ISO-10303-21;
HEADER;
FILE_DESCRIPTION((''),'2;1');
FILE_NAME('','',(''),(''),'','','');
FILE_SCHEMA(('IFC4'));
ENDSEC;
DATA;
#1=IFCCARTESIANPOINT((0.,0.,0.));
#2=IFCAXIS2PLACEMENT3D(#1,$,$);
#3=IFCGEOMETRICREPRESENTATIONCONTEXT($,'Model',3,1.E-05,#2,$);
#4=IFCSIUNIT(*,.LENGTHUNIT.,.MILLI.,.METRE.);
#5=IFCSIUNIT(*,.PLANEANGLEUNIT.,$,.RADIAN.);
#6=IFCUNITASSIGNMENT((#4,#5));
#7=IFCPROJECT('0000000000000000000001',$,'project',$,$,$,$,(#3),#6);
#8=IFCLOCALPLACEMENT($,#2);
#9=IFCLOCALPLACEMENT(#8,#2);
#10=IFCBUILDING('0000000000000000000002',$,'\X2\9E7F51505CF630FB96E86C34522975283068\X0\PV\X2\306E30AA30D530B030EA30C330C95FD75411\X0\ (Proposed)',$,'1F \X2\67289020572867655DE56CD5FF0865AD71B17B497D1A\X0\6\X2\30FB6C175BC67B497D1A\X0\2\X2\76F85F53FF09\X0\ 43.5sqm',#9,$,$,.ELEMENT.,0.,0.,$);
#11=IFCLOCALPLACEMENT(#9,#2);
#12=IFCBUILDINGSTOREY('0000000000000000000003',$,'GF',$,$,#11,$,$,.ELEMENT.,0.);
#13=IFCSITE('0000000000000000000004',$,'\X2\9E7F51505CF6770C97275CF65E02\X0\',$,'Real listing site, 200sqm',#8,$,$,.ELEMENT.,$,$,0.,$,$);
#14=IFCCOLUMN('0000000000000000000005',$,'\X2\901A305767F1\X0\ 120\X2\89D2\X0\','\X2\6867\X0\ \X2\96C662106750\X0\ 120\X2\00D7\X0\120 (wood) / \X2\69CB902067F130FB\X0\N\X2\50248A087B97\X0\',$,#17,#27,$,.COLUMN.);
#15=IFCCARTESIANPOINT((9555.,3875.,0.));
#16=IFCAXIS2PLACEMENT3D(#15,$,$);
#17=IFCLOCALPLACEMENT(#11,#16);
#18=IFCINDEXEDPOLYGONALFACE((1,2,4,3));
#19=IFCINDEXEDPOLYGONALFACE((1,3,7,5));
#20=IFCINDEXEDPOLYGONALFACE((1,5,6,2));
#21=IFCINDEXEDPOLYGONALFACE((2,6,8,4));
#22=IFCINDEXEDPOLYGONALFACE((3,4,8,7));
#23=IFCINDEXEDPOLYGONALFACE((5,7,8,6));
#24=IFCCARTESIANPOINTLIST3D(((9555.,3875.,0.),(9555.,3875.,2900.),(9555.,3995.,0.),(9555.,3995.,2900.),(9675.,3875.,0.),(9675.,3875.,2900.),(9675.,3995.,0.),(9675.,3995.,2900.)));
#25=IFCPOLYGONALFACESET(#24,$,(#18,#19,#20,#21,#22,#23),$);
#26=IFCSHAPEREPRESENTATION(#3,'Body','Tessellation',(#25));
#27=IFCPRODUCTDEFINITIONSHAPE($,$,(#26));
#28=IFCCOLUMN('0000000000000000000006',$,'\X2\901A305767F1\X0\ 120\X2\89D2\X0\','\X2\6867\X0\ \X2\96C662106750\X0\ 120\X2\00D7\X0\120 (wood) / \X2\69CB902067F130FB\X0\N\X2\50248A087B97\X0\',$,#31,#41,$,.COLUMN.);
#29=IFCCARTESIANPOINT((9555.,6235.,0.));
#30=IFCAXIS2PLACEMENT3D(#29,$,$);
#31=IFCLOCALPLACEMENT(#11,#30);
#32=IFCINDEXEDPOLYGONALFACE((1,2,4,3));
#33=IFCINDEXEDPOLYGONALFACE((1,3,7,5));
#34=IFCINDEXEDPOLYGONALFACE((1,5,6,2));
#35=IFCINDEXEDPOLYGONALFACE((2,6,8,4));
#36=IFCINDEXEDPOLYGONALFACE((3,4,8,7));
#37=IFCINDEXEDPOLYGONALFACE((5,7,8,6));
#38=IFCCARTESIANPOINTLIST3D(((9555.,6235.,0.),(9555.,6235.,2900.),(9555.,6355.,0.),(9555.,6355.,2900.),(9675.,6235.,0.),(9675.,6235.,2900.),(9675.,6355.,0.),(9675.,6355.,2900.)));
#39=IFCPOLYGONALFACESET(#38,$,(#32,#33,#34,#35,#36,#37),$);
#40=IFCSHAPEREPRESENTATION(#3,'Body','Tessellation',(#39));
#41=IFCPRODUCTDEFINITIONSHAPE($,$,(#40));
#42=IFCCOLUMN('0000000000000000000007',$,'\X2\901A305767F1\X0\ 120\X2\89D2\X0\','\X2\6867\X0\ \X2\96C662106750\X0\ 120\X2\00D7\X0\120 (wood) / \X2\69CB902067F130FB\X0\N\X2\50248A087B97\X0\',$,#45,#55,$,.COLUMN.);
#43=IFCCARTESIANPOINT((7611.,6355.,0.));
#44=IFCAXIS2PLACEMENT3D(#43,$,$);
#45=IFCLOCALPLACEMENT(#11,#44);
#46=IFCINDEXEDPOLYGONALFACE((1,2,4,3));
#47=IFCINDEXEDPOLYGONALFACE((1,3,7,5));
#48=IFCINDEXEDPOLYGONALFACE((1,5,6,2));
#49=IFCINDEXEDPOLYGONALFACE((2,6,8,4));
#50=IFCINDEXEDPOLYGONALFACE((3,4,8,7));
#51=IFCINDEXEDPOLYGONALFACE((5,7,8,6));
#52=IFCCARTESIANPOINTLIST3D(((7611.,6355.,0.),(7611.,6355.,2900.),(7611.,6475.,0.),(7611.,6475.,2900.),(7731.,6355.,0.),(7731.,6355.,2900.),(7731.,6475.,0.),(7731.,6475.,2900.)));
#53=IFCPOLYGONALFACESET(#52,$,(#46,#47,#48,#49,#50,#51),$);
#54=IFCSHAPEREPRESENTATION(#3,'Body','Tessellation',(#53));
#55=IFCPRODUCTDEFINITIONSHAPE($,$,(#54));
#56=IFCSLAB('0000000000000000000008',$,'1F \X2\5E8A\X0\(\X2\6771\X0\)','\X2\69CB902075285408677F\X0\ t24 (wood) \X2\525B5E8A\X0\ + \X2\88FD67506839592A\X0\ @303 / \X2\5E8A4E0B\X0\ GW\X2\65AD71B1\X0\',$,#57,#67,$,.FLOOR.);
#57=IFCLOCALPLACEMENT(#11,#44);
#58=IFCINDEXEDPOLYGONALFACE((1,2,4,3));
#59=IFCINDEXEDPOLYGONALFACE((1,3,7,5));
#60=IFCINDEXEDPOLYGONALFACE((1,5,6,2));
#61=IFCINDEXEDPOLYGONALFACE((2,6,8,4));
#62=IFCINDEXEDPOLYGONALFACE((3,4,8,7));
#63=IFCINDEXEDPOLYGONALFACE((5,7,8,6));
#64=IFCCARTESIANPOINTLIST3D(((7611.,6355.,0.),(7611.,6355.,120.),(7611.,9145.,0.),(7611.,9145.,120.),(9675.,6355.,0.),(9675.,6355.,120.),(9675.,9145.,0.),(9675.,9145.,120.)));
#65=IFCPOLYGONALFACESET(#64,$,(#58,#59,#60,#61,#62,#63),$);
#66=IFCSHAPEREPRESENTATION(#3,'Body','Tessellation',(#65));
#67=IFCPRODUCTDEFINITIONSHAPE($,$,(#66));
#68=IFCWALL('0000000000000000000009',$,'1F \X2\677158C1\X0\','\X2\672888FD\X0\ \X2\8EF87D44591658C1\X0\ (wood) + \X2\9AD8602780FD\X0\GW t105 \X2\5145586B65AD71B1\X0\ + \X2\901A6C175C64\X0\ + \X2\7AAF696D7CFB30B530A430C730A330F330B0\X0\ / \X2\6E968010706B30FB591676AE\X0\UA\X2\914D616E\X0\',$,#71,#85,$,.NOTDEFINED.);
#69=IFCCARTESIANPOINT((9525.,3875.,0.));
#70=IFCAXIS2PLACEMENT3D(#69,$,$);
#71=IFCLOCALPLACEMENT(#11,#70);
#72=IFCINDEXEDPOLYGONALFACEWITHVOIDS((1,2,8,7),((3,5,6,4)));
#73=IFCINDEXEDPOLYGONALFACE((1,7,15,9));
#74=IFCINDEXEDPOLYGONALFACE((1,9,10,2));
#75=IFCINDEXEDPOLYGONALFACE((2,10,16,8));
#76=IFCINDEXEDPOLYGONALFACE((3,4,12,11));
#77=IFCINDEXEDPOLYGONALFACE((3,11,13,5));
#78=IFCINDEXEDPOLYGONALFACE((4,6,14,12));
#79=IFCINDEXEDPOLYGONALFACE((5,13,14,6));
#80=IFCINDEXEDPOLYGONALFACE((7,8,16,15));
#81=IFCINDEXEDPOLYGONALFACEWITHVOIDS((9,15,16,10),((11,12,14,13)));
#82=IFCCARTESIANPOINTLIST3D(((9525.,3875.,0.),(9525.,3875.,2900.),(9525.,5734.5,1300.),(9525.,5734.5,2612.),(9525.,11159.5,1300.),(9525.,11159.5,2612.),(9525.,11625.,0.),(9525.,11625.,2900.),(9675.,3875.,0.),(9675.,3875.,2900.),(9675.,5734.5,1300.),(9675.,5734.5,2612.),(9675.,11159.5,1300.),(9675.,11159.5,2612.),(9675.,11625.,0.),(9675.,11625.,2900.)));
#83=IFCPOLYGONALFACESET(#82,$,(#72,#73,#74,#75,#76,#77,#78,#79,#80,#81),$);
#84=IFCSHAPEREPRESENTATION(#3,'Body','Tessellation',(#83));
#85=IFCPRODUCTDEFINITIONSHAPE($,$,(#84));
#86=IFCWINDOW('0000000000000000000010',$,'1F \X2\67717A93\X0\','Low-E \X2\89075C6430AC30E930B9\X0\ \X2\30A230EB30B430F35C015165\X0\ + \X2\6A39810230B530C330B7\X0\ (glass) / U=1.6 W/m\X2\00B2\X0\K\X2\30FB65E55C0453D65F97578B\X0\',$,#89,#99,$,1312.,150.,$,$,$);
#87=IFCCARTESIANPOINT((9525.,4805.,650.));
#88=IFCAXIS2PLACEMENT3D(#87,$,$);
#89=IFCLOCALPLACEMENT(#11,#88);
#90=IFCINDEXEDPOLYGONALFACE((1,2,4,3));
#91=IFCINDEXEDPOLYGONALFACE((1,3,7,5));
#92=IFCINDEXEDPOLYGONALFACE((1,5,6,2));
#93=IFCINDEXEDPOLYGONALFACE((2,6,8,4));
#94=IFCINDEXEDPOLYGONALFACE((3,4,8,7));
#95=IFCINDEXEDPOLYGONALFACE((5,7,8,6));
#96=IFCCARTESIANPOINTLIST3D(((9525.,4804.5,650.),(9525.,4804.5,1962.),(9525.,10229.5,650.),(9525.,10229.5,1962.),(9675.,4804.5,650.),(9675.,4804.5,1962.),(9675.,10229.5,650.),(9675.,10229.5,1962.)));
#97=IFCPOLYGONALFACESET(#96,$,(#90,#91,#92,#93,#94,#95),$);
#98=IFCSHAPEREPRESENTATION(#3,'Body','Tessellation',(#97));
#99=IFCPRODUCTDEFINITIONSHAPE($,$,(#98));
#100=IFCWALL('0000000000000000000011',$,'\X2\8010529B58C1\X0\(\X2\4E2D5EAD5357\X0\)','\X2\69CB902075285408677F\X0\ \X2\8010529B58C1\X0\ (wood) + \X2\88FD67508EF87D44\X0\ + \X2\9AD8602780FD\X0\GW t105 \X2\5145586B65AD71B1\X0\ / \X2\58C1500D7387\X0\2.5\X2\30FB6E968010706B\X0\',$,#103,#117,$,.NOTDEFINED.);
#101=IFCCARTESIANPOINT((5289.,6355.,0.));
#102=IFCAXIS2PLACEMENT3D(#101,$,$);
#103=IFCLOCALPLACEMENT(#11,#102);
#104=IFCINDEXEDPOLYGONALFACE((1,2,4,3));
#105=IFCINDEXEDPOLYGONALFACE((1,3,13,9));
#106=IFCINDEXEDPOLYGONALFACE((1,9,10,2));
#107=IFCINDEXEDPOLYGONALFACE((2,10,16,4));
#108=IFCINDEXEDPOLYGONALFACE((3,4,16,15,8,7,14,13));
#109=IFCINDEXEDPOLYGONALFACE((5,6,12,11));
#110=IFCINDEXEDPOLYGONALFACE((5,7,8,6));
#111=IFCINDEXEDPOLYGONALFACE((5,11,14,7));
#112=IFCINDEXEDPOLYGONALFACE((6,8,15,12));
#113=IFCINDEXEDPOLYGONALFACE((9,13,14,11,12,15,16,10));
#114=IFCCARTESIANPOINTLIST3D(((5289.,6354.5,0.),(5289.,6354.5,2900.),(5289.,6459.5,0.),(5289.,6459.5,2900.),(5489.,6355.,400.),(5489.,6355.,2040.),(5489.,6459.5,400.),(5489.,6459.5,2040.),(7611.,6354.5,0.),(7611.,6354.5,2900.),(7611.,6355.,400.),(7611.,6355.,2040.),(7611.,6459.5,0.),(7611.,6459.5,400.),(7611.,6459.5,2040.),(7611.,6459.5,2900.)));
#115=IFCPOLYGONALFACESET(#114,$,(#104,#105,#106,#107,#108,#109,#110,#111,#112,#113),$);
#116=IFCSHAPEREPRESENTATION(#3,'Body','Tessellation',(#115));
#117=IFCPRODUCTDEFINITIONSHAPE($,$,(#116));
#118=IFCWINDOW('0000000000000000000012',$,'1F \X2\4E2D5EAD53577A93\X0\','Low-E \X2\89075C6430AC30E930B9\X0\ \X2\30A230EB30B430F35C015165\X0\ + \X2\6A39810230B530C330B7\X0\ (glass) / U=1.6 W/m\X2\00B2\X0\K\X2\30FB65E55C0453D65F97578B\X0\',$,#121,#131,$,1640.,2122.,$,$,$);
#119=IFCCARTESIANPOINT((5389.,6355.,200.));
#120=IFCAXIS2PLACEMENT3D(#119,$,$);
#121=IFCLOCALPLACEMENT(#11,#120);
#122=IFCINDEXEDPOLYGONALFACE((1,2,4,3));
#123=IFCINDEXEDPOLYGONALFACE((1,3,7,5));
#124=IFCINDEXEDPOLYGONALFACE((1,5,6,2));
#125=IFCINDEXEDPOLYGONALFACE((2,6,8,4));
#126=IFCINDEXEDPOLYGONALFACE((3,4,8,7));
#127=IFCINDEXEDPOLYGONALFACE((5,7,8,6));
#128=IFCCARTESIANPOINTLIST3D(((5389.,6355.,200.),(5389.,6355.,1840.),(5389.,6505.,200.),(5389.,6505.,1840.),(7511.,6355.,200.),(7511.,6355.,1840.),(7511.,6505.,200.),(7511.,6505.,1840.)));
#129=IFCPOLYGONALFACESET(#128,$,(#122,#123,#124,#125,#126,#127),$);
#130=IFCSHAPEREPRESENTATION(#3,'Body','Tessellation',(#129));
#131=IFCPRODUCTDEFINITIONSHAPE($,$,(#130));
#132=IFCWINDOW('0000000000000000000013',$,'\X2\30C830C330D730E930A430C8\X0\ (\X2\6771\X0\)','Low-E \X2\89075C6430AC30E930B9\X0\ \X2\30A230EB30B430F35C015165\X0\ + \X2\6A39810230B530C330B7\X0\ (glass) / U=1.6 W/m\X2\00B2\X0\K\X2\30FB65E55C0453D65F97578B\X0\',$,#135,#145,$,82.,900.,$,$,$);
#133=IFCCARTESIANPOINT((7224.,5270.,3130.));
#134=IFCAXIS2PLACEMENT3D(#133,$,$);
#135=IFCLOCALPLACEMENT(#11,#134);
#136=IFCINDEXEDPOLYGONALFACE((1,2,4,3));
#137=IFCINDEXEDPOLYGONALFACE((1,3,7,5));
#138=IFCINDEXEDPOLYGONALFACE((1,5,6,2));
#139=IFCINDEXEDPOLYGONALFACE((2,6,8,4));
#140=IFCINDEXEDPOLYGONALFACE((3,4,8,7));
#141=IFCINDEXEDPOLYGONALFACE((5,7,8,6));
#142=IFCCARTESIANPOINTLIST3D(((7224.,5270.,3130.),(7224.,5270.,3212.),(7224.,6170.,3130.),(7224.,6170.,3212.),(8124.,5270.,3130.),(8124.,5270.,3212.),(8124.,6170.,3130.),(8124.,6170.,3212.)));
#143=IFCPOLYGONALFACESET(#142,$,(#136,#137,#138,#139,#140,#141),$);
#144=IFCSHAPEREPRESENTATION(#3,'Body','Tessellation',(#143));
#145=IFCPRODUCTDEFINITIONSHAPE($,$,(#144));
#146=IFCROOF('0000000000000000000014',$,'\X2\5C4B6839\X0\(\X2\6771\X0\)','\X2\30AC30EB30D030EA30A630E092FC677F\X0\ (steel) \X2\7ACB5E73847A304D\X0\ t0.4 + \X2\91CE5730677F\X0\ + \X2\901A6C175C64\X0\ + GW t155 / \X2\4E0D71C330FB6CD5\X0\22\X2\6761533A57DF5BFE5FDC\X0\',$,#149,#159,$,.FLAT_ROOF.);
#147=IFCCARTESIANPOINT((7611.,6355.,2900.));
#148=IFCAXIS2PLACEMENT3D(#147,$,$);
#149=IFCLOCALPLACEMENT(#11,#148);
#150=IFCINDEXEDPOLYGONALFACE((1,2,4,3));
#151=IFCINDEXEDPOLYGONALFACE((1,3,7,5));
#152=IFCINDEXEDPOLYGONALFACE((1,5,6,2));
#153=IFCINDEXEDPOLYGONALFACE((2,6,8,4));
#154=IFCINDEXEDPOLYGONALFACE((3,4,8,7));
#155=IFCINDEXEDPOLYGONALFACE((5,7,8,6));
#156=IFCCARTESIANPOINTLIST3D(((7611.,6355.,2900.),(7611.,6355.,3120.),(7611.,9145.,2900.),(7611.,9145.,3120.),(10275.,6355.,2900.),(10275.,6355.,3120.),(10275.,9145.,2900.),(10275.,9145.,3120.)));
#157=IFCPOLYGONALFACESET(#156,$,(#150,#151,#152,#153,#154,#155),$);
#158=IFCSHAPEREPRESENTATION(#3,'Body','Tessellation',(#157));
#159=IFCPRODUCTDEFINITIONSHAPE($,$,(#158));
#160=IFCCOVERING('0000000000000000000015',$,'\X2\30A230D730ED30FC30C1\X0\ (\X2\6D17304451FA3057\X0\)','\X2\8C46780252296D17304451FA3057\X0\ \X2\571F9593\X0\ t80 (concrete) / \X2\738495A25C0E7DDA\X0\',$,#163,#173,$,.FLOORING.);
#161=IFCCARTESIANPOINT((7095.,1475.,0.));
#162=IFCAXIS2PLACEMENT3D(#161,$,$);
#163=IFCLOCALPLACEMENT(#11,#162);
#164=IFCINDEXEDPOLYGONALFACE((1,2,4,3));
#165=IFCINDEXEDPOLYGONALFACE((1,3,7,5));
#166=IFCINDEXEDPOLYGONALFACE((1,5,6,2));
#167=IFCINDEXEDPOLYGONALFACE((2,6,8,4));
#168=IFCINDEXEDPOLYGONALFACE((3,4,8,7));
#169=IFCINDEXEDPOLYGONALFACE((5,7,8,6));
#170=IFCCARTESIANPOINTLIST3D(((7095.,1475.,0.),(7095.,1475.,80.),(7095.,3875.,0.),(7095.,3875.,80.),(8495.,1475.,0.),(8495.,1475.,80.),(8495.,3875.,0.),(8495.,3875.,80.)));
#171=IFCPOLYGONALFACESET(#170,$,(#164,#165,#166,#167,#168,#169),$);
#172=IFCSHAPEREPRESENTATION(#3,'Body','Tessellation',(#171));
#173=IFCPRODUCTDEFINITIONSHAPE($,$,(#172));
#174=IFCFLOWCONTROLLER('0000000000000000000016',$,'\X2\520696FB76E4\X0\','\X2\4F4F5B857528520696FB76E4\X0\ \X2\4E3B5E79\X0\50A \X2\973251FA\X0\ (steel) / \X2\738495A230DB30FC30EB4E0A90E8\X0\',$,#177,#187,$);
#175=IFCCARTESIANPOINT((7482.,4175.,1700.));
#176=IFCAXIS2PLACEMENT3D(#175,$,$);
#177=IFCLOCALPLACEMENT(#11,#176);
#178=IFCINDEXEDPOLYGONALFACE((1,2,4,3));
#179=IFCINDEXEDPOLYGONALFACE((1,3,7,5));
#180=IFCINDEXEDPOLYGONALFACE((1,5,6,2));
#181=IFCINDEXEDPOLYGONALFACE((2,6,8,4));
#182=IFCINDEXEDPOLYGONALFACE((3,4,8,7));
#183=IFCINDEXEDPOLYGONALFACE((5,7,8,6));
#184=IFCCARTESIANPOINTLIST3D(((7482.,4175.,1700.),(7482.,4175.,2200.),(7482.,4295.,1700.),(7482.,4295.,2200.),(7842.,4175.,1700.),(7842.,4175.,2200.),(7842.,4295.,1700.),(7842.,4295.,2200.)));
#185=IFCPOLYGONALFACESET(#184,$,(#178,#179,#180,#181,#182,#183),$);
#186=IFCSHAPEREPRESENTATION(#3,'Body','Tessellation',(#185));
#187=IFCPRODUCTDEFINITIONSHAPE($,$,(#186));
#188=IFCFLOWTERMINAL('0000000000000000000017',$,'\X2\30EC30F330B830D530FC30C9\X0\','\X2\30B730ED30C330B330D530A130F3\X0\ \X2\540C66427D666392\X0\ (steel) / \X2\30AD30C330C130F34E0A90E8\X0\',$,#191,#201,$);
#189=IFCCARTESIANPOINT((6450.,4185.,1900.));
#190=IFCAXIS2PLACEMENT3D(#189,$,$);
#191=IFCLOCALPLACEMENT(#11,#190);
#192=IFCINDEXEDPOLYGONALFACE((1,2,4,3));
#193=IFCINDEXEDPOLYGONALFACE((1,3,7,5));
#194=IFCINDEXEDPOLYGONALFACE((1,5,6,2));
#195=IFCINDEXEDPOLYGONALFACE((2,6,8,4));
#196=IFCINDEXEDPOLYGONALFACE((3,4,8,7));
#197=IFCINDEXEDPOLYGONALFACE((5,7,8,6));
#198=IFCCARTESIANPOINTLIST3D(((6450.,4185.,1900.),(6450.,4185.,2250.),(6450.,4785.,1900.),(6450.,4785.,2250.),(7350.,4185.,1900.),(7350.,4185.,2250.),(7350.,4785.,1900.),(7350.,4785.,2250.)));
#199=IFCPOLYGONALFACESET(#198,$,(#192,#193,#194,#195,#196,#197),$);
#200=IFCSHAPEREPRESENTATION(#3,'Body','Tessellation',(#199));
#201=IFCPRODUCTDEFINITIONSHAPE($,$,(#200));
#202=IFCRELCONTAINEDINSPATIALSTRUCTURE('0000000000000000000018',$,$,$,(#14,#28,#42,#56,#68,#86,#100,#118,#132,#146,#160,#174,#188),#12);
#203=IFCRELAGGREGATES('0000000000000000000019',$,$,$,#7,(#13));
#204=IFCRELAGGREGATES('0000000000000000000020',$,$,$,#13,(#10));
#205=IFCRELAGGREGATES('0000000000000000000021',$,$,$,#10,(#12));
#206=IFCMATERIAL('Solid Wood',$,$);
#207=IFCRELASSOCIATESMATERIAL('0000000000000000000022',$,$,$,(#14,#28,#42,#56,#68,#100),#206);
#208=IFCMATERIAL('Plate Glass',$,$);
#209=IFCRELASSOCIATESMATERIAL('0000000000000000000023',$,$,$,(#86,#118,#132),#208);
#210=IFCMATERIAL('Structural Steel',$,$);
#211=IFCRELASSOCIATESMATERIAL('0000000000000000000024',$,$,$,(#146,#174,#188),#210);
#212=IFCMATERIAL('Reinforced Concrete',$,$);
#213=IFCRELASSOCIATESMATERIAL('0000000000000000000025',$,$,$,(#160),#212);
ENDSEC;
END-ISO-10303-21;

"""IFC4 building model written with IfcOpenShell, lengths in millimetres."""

from ifc_helpers import new_model, si_unit, frame, frame_2d, origin, place, context, project, spatial, rectangle, extrude, material, element, fill, save


model = new_model("IFC4")

# Units and contexts
model_context = context("Model", 3, precision=1e-05, world=origin())
ifc_project = project(units=[si_unit("LENGTHUNIT", "METRE", prefix="MILLI"), si_unit("PLANEANGLEUNIT", "RADIAN")], contexts=[model_context])

# Site, building, storey
site_placement = place(None, origin())
site = spatial("IfcSite", under=ifc_project, at=site_placement, Name="鹿児島県霧島市", ObjectType="Real listing site, 200sqm", CompositionType="ELEMENT", RefElevation=0.0)
building_placement = place(site_placement, origin())
building = spatial("IfcBuilding", under=site, at=building_placement, Name="鹿児島・雨水利用とPVのオフグリッド志向 (Proposed)", ObjectType="1F 木造在来工法（断熱等級6・気密等級2相当） 43.5sqm", CompositionType="ELEMENT", ElevationOfRefHeight=0.0, ElevationOfTerrain=0.0)
storey_placement = place(building_placement, origin())
storey = spatial("IfcBuildingStorey", under=building, at=storey_placement, Name="GF", CompositionType="ELEMENT", Elevation=0.0)

# Columns
ifc_material_1 = material(Name="Solid Wood")
column_1_placement = place(storey_placement, frame((9555.0, 3875.0, 0.0)))
element("IfcColumn", 1, at=column_1_placement, inside=storey, material=ifc_material_1, Name="通し柱 120角", Description="桧 集成材 120×120 (wood) / 構造柱・N値計算", PredefinedType="COLUMN", context=model_context, shape_type="SweptSolid", body=[
    extrude(rectangle(XDim=120.0, YDim=120.0, at=frame_2d((60.0, 60.0))), frame((9555.0, 3875.0, 0.0)), (0.0, 0.0, 1.0), 2900.0),
])
column_2_placement = place(storey_placement, frame((9555.0, 6235.0, 0.0)))
element("IfcColumn", 2, at=column_2_placement, inside=storey, material=ifc_material_1, Name="通し柱 120角", Description="桧 集成材 120×120 (wood) / 構造柱・N値計算", PredefinedType="COLUMN", context=model_context, shape_type="SweptSolid", body=[
    extrude(rectangle(XDim=120.0, YDim=120.0, at=frame_2d((60.0, 60.0))), frame((9555.0, 6235.0, 0.0)), (0.0, 0.0, 1.0), 2900.0),
])
column_3_placement = place(storey_placement, frame((7611.0, 6355.0, 0.0)))
element("IfcColumn", 3, at=column_3_placement, inside=storey, material=ifc_material_1, Name="通し柱 120角", Description="桧 集成材 120×120 (wood) / 構造柱・N値計算", PredefinedType="COLUMN", context=model_context, shape_type="SweptSolid", body=[
    extrude(rectangle(XDim=120.0, YDim=120.0, at=frame_2d((60.0, 60.0))), frame((7611.0, 6355.0, 0.0)), (0.0, 0.0, 1.0), 2900.0),
])

# Slab
slab_placement = place(storey_placement, frame((7611.0, 6355.0, 0.0)))
element("IfcSlab", 4, at=slab_placement, inside=storey, material=ifc_material_1, Name="1F 床(東)", Description="構造用合板 t24 (wood) 剛床 + 製材根太 @303 / 床下 GW断熱", PredefinedType="FLOOR", context=model_context, shape_type="SweptSolid", body=[
    extrude(rectangle(XDim=2064.0, YDim=2790.0, at=frame_2d((1032.0, 1395.0))), frame((7611.0, 6355.0, 0.0)), (0.0, 0.0, 1.0), 120.0),
])

# Walls, openings, windows
wall_1_placement = place(storey_placement, frame((9525.0, 3875.0, 0.0)))
wall_1 = element("IfcWall", 5, at=wall_1_placement, inside=storey, material=ifc_material_1, Name="1F 東壁", Description="木製 軸組外壁 (wood) + 高性能GW t105 充填断熱 + 通気層 + 窯業系サイディング / 準耐火・外皮UA配慮", PredefinedType="NOTDEFINED", context=model_context, shape_type="SweptSolid", body=[
    extrude(rectangle(XDim=150.0, YDim=7750.0, at=frame_2d((75.0, 3875.0))), frame((9525.0, 3875.0, 0.0)), (0.0, 0.0, 1.0), 2900.0),
])
opening_1_placement = place(storey_placement, frame((9525.0, 4805.0, 650.0)))
opening_1 = element("IfcOpeningElement", 6, at=opening_1_placement, cuts=wall_1, PredefinedType="NOTDEFINED", context=model_context, shape_type="SweptSolid", body=[
    extrude(rectangle(XDim=150.0, YDim=5425.0, at=frame_2d((75.0, 2712.0))), frame((9525.0, 4805.0, 650.0)), (0.0, 0.0, 1.0), 1312.0),
])
ifc_material_2 = material(Name="Plate Glass")
window_1_placement = place(storey_placement, frame((9525.0, 4805.0, 650.0)))
window_1 = element("IfcWindow", 7, at=window_1_placement, inside=storey, material=ifc_material_2, Name="1F 東窓", Description="Low-E 複層ガラス アルゴン封入 + 樹脂サッシ (glass) / U=1.6 W/m²K・日射取得型", OverallHeight=1312.0, OverallWidth=150.0, context=model_context, shape_type="SweptSolid", body=[
    extrude(rectangle(XDim=150.0, YDim=5425.0, at=frame_2d((75.0, 2712.0))), frame((9525.0, 4805.0, 650.0)), (0.0, 0.0, 1.0), 1312.0),
])
fill(opening_1, window_1)
wall_2_placement = place(storey_placement, frame((5289.0, 6355.0, 0.0)))
wall_2 = element("IfcWall", 8, at=wall_2_placement, inside=storey, material=ifc_material_1, Name="耐力壁(中庭南)", Description="構造用合板 耐力壁 (wood) + 製材軸組 + 高性能GW t105 充填断熱 / 壁倍率2.5・準耐火", PredefinedType="NOTDEFINED", context=model_context, shape_type="SweptSolid", body=[
    extrude(rectangle(XDim=2322.0, YDim=105.0, at=frame_2d((1161.0, 52.0))), frame((5289.0, 6355.0, 0.0)), (0.0, 0.0, 1.0), 2900.0),
])
opening_2_placement = place(storey_placement, frame((5389.0, 6355.0, 200.0)))
opening_2 = element("IfcOpeningElement", 9, at=opening_2_placement, cuts=wall_2, PredefinedType="NOTDEFINED", context=model_context, shape_type="SweptSolid", body=[
    extrude(rectangle(XDim=2122.0, YDim=150.0, at=frame_2d((1061.0, 75.0))), frame((5389.0, 6355.0, 200.0)), (0.0, 0.0, 1.0), 1640.0),
])
window_2_placement = place(storey_placement, frame((5389.0, 6355.0, 200.0)))
window_2 = element("IfcWindow", 10, at=window_2_placement, inside=storey, material=ifc_material_2, Name="1F 中庭南窓", Description="Low-E 複層ガラス アルゴン封入 + 樹脂サッシ (glass) / U=1.6 W/m²K・日射取得型", OverallHeight=1640.0, OverallWidth=2122.0, context=model_context, shape_type="SweptSolid", body=[
    extrude(rectangle(XDim=2122.0, YDim=150.0, at=frame_2d((1061.0, 75.0))), frame((5389.0, 6355.0, 200.0)), (0.0, 0.0, 1.0), 1640.0),
])
fill(opening_2, window_2)

# Window
window_3_placement = place(storey_placement, frame((7224.0, 5270.0, 3130.0)))
element("IfcWindow", 11, at=window_3_placement, inside=storey, material=ifc_material_2, Name="トップライト (東)", Description="Low-E 複層ガラス アルゴン封入 + 樹脂サッシ (glass) / U=1.6 W/m²K・日射取得型", OverallHeight=82.0, OverallWidth=900.0, context=model_context, shape_type="SweptSolid", body=[
    extrude(rectangle(XDim=900.0, YDim=900.0, at=frame_2d((450.0, 450.0))), frame((7224.0, 5270.0, 3130.0)), (0.0, 0.0, 1.0), 82.0),
])

# Roof
ifc_material_3 = material(Name="Structural Steel")
roof_placement = place(storey_placement, frame((7611.0, 6355.0, 2900.0)))
element("IfcRoof", 12, at=roof_placement, inside=storey, material=ifc_material_3, Name="屋根(東)", Description="ガルバリウム鋼板 (steel) 立平葺き t0.4 + 野地板 + 通気層 + GW t155 / 不燃・法22条区域対応", PredefinedType="FLAT_ROOF", context=model_context, shape_type="SweptSolid", body=[
    extrude(rectangle(XDim=2664.0, YDim=2790.0, at=frame_2d((1332.0, 1395.0))), frame((7611.0, 6355.0, 2900.0)), (0.0, 0.0, 1.0), 220.0),
])

# Covering
ifc_material_4 = material(Name="Reinforced Concrete")
covering_placement = place(storey_placement, frame((7095.0, 1475.0, 0.0)))
element("IfcCovering", 13, at=covering_placement, inside=storey, material=ifc_material_4, Name="アプローチ (洗い出し)", Description="豆砂利洗い出し 土間 t80 (concrete) / 玄関導線", PredefinedType="FLOORING", context=model_context, shape_type="SweptSolid", body=[
    extrude(rectangle(XDim=1400.0, YDim=2400.0, at=frame_2d((700.0, 1200.0))), frame((7095.0, 1475.0, 0.0)), (0.0, 0.0, 1.0), 80.0),
])

# Flow controller
flow_controller_placement = place(storey_placement, frame((7482.0, 4175.0, 1700.0)))
element("IfcFlowController", 14, at=flow_controller_placement, inside=storey, material=ifc_material_3, Name="分電盤", Description="住宅用分電盤 主幹50A 露出 (steel) / 玄関ホール上部", context=model_context, shape_type="SweptSolid", body=[
    extrude(rectangle(XDim=360.0, YDim=120.0, at=frame_2d((180.0, 60.0))), frame((7482.0, 4175.0, 1700.0)), (0.0, 0.0, 1.0), 500.0),
])

# Flow terminal
flow_terminal_1_placement = place(storey_placement, frame((6450.0, 4185.0, 1900.0)))
element("IfcFlowTerminal", 15, at=flow_terminal_1_placement, inside=storey, material=ifc_material_3, Name="レンジフード", Description="シロッコファン 同時給排 (steel) / キッチン上部", context=model_context, shape_type="SweptSolid", body=[
    extrude(rectangle(XDim=900.0, YDim=600.0, at=frame_2d((450.0, 300.0))), frame((6450.0, 4185.0, 1900.0)), (0.0, 0.0, 1.0), 350.0),
])

save(model, "model.ifc")
